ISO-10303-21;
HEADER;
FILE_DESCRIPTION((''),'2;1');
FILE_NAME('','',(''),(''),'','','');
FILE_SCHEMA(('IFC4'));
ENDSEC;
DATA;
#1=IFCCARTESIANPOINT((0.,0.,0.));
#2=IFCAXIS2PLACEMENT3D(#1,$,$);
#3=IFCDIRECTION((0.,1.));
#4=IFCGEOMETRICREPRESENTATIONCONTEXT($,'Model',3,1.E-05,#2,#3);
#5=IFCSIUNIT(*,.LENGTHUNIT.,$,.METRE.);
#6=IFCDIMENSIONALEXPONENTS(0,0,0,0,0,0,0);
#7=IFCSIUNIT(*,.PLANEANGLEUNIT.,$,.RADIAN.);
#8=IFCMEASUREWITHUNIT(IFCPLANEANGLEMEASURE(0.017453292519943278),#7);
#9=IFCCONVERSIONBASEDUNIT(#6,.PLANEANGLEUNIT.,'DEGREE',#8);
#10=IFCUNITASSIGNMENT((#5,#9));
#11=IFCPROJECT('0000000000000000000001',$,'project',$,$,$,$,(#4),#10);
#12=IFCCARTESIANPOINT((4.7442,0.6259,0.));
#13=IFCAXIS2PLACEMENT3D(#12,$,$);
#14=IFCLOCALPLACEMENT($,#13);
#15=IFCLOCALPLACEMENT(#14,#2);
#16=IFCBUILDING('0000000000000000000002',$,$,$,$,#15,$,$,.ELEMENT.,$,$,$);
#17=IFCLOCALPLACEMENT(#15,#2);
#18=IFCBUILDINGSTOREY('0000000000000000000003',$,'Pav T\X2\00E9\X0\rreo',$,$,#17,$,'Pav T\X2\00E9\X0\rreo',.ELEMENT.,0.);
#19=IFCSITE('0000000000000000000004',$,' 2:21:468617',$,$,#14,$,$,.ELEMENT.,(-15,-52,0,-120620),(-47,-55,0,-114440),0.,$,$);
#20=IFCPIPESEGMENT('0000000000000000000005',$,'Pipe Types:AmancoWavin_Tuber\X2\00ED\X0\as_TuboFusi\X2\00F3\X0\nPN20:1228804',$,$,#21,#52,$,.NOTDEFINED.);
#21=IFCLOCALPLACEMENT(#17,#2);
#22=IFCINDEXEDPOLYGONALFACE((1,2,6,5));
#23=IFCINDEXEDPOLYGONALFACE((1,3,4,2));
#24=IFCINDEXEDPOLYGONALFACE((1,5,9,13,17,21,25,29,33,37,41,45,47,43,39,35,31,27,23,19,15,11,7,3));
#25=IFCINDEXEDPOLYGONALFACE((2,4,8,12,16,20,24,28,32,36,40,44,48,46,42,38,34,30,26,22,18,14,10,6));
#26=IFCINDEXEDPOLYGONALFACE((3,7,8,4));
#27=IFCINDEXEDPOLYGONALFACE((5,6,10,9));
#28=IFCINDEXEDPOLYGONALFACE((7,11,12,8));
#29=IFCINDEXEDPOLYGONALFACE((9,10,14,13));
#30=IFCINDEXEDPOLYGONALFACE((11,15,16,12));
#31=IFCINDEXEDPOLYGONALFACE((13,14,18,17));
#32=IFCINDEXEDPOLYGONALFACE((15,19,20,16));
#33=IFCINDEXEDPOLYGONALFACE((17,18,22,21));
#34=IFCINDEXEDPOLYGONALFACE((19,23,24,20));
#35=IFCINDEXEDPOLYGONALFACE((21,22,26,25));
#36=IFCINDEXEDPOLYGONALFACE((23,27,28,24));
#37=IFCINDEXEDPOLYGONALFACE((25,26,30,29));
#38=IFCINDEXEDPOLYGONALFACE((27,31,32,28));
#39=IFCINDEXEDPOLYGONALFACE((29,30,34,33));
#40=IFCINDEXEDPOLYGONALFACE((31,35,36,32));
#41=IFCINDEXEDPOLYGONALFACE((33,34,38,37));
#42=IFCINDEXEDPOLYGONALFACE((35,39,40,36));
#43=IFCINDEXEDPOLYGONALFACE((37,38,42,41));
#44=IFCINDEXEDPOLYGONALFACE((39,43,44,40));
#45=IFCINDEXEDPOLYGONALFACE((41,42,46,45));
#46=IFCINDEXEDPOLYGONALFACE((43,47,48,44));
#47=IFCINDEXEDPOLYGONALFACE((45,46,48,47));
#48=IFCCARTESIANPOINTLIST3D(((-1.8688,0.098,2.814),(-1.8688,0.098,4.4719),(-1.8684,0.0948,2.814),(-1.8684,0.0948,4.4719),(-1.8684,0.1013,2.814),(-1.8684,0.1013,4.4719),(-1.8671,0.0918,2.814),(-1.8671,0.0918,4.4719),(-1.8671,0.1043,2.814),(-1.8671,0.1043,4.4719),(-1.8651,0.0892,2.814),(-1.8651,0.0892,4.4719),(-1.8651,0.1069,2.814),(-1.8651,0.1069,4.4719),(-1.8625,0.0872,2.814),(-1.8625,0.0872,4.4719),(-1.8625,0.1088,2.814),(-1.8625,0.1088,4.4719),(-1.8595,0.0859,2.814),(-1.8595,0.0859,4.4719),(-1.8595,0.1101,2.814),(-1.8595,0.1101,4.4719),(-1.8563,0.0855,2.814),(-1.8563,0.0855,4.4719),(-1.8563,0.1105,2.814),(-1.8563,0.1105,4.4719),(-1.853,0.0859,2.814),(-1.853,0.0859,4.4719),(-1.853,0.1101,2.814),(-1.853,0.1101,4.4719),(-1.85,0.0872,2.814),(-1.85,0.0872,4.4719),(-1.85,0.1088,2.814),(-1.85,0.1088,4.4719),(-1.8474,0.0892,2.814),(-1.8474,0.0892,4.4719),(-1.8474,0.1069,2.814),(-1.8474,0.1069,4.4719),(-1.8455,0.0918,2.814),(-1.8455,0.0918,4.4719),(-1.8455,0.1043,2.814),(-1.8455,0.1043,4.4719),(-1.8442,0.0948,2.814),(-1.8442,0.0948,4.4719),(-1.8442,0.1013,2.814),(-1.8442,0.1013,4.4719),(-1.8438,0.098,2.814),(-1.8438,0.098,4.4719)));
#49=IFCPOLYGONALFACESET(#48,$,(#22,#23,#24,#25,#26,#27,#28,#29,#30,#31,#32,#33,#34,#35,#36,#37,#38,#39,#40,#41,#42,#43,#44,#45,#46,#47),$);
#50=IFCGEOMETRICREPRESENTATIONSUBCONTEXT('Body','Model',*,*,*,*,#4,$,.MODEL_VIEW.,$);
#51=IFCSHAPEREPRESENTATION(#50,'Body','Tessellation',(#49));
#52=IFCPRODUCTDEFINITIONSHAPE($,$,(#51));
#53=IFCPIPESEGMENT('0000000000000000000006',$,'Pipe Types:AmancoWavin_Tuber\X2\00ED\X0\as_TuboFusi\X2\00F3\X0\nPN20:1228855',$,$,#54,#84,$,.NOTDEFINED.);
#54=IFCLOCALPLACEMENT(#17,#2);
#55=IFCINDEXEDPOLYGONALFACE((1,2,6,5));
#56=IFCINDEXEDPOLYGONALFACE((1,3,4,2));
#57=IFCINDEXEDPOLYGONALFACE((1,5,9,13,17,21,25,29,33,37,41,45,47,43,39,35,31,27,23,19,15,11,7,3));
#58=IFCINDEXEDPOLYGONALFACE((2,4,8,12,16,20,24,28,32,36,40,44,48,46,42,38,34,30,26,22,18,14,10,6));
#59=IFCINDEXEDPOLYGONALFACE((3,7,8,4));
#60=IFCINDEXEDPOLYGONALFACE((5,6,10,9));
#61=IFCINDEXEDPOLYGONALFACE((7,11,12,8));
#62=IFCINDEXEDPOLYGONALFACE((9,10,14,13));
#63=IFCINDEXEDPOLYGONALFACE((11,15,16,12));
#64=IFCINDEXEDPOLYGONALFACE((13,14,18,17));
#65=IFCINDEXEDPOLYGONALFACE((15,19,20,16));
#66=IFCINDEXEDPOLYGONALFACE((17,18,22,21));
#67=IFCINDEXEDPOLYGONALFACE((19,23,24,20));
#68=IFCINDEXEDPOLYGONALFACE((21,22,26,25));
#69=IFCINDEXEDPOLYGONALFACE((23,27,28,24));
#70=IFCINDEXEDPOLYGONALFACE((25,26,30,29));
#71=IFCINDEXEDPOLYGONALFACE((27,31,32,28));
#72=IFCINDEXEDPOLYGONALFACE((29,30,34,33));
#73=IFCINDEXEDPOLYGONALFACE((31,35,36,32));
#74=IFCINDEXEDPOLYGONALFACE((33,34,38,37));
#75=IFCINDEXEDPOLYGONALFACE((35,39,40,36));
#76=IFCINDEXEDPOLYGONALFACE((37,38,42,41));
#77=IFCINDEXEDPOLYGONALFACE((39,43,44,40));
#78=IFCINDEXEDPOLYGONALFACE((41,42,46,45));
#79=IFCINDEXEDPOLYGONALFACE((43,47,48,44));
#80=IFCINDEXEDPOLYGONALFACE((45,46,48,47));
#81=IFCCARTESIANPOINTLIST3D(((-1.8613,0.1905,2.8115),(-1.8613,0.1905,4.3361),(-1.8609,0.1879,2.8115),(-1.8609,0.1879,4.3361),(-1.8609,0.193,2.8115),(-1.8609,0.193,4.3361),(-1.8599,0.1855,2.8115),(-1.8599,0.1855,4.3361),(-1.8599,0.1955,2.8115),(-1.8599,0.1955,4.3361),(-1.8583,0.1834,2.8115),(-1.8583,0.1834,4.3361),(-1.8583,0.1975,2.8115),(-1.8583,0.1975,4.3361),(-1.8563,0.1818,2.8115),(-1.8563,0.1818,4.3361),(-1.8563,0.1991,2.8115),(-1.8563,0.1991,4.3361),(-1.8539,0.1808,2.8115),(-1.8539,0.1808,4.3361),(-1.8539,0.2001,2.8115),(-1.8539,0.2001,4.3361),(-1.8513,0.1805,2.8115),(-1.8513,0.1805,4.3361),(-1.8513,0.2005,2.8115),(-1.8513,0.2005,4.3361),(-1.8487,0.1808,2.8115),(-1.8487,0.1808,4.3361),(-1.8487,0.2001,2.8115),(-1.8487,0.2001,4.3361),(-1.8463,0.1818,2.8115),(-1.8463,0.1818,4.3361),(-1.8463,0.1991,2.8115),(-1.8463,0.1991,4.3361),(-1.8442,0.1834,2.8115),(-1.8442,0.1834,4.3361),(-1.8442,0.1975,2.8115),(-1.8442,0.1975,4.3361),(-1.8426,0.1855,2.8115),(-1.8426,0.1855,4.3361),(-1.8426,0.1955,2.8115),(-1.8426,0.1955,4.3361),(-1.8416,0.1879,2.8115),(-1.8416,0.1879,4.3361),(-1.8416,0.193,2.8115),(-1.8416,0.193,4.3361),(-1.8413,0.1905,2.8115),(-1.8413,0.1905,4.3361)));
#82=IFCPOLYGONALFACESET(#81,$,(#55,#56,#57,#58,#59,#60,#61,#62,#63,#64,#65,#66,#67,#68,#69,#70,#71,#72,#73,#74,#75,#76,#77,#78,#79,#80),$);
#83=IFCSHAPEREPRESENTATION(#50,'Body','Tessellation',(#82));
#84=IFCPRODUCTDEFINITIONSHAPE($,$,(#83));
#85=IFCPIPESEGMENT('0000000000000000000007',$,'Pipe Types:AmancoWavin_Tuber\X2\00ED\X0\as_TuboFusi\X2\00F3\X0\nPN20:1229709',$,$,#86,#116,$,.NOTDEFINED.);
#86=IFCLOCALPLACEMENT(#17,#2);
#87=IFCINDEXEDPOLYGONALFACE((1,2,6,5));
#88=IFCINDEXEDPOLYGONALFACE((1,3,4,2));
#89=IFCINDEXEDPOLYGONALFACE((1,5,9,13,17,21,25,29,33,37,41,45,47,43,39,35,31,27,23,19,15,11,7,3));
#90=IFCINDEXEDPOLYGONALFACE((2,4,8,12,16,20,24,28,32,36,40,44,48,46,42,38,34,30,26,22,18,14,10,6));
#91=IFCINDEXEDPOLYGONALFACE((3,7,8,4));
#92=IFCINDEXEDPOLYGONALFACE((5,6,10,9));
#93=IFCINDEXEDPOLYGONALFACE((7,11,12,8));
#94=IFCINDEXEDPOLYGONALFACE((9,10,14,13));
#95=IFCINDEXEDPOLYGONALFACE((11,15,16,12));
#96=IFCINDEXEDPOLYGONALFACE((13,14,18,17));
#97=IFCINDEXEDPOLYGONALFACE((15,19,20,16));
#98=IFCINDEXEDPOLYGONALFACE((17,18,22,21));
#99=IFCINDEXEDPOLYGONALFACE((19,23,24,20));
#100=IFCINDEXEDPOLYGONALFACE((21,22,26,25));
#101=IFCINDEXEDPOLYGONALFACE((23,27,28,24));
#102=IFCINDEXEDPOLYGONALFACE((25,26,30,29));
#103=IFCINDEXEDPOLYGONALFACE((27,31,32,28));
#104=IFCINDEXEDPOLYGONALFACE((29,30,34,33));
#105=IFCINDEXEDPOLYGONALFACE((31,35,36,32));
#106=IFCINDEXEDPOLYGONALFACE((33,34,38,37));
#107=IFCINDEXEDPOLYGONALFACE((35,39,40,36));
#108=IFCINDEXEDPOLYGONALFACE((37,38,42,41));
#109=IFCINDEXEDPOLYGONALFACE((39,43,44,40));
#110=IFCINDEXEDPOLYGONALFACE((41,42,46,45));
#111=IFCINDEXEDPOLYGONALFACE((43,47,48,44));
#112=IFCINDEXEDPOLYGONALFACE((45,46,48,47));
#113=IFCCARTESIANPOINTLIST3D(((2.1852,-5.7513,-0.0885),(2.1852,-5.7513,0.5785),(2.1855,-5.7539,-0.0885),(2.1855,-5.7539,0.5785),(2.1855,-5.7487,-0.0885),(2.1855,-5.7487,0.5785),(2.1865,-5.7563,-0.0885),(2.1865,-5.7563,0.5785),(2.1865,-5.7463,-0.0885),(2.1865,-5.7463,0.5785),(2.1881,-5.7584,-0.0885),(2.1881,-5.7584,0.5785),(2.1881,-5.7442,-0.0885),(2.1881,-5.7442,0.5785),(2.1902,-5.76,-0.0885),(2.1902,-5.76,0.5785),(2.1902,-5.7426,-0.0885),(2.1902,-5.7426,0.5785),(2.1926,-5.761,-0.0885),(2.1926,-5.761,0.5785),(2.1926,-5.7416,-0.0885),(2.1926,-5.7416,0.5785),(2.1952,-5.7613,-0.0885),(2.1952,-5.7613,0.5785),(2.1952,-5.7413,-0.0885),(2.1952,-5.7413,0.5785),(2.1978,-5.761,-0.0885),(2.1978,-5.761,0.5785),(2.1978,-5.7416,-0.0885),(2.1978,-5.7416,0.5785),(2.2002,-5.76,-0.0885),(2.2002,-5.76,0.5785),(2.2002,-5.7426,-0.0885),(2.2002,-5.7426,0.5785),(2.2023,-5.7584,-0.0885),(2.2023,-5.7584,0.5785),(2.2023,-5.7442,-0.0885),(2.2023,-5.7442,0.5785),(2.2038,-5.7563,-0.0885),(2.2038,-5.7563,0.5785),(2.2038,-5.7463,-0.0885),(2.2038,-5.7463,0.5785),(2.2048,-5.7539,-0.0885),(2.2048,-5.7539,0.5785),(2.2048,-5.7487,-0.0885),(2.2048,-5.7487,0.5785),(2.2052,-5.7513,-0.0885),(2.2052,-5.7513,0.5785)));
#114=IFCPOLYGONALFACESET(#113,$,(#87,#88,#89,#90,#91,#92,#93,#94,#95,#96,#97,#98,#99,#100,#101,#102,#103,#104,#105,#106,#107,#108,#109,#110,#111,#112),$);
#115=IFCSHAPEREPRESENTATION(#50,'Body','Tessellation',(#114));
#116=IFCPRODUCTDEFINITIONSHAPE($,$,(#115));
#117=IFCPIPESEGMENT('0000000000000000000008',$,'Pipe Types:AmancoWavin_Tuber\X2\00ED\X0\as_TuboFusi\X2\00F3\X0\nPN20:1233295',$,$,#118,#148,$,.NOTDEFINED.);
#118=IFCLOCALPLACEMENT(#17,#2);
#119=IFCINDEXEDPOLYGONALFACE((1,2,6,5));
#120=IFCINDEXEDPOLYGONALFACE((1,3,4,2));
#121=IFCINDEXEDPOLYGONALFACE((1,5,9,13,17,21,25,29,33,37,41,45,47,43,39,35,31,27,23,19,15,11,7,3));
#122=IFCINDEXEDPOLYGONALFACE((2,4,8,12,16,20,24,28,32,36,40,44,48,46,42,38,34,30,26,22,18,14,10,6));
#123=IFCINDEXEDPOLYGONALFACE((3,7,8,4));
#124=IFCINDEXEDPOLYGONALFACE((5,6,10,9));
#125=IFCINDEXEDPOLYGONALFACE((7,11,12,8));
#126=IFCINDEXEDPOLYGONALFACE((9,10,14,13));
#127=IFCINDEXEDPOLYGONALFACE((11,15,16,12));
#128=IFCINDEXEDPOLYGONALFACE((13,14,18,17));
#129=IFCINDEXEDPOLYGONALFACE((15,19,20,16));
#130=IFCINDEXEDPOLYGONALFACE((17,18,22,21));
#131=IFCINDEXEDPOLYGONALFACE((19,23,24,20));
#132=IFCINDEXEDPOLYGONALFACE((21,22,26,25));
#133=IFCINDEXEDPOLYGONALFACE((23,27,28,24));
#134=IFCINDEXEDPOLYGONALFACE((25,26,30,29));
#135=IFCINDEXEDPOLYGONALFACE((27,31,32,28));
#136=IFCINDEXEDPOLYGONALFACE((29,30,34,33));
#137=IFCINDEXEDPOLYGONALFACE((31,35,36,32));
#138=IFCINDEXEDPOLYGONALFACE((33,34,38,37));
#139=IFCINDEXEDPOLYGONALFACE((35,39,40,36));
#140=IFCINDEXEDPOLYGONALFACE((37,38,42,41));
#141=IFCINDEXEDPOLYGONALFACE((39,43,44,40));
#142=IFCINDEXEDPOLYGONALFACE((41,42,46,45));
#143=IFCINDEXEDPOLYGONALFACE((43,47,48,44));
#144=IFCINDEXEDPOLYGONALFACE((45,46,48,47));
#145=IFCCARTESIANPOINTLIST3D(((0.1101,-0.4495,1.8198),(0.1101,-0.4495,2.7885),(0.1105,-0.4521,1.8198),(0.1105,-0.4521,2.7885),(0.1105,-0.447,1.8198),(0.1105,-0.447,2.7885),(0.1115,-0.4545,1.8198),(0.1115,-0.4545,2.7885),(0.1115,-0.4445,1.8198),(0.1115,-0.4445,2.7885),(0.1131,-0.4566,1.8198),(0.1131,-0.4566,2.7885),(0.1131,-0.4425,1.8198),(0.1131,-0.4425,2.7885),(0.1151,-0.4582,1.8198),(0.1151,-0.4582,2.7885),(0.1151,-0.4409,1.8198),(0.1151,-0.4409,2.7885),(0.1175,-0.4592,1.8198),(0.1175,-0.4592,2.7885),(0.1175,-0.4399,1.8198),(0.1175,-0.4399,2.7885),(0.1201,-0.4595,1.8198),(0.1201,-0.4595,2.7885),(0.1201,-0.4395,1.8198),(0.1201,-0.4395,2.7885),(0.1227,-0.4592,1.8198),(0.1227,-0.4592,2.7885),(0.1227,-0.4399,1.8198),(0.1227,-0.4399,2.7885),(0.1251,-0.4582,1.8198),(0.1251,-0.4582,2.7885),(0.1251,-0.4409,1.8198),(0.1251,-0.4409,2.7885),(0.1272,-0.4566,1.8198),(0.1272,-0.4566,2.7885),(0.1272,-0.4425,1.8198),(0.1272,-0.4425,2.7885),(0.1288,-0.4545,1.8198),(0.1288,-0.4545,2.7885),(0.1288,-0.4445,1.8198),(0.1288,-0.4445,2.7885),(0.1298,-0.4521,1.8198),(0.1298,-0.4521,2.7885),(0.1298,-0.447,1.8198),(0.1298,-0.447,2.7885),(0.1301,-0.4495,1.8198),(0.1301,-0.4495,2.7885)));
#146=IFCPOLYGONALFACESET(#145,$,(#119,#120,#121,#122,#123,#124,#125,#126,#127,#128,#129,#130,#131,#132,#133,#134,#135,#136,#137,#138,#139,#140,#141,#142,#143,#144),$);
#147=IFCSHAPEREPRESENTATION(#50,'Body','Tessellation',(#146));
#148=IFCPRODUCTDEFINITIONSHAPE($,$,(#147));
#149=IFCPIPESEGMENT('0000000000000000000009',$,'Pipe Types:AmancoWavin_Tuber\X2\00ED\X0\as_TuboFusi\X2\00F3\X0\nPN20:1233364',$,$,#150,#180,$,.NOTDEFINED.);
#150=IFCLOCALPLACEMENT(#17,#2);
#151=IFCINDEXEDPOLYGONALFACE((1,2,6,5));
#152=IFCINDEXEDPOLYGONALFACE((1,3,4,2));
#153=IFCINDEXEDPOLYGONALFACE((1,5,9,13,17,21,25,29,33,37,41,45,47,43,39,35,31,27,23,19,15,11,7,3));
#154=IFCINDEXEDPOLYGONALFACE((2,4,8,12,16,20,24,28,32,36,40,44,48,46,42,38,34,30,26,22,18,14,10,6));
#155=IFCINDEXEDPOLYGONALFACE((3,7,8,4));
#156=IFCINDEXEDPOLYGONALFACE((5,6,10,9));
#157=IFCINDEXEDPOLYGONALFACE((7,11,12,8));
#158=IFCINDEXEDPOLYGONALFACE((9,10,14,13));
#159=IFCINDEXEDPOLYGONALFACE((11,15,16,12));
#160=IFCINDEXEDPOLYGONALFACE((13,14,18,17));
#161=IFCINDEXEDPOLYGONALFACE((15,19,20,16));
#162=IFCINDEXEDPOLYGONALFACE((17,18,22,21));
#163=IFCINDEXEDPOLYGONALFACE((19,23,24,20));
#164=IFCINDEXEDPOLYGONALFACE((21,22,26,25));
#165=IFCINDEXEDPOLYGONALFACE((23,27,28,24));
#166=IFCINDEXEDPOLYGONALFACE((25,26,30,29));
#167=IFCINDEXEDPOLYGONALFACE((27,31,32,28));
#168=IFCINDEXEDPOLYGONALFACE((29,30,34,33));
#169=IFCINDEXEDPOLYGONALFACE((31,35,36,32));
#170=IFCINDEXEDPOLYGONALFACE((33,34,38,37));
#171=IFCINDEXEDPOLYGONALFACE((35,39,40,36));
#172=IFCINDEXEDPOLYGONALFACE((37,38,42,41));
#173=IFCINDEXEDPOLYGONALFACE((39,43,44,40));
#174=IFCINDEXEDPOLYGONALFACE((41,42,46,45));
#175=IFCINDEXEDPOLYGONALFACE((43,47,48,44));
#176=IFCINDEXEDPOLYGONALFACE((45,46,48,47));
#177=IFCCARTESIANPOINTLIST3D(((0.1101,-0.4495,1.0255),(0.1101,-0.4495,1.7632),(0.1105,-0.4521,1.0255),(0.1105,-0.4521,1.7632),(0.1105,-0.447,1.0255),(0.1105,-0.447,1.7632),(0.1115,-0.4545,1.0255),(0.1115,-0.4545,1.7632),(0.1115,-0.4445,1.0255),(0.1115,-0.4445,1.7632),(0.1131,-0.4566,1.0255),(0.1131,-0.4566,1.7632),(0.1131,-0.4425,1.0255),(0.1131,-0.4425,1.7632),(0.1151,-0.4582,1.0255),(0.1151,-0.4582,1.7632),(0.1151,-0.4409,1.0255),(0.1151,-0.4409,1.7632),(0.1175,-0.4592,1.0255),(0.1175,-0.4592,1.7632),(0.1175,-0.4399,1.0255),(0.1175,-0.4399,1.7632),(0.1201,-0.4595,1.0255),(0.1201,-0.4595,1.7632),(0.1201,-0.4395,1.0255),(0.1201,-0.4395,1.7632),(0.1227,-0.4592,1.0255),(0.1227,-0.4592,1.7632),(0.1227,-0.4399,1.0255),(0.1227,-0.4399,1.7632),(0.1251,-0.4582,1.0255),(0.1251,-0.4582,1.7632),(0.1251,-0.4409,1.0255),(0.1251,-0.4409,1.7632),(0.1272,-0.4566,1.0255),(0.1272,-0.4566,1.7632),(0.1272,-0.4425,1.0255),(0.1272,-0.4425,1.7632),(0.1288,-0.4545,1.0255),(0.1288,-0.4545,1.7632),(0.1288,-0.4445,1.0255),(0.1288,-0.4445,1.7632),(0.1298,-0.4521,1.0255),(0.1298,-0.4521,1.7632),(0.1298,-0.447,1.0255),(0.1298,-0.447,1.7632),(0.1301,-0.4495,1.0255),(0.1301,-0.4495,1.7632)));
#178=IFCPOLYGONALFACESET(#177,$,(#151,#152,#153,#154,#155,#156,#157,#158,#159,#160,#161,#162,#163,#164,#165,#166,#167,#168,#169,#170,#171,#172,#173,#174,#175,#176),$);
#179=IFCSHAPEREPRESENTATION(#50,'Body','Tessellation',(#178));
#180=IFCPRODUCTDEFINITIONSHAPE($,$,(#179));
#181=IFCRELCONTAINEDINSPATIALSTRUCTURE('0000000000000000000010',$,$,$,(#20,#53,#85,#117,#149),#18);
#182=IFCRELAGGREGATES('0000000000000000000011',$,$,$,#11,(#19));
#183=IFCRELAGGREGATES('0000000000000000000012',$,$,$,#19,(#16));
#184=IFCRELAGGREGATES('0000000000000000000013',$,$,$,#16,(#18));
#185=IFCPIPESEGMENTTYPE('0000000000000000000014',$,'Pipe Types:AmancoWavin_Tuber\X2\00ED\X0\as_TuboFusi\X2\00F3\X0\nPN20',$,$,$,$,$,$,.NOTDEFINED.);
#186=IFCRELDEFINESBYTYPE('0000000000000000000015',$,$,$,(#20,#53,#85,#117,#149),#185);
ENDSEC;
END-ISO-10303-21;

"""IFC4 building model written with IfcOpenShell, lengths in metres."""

from ifc_helpers import new_model, entity, si_unit, converted_unit, direction, frame, origin, place, context, subcontext, project, spatial, arc, indexed_curve, outline, extrude, type_object, element, save


model = new_model("IFC4")

# Units and contexts
model_context = context("Model", 3, precision=1e-05, world=origin(), true_north=direction((0.0, 1.0)))
body_context = subcontext(model_context, "Body", "Model", "MODEL_VIEW")
ifc_project = project(units=[si_unit("LENGTHUNIT", "METRE"), converted_unit("PLANEANGLEUNIT", "DEGREE", entity("IfcPlaneAngleMeasure", 0.017453292519943278), si_unit("PLANEANGLEUNIT", "RADIAN"), dimensions=[0, 0, 0, 0, 0, 0, 0])], contexts=[model_context])

# Site, building, storey
site_placement = place(None, frame((4.7442, 0.6259, 0.0)))
site = spatial("IfcSite", under=ifc_project, at=site_placement, Name=" 2:21:468617", CompositionType="ELEMENT", RefLatitude=(-15, -52, 0, -120620), RefLongitude=(-47, -55, 0, -114440), RefElevation=0.0)
building_placement = place(site_placement, origin())
building = spatial("IfcBuilding", under=site, at=building_placement, CompositionType="ELEMENT")
storey_placement = place(building_placement, origin())
storey = spatial("IfcBuildingStorey", under=building, at=storey_placement, Name="Pav Térreo", LongName="Pav Térreo", CompositionType="ELEMENT", Elevation=0.0)

# Pipe segments
pipe_segment_type_1 = type_object("IfcPipeSegmentType", Name="Pipe Types:AmancoWavin_Tuberías_TuboFusiónPN20", PredefinedType="NOTDEFINED")
pipe_segment_1_placement = place(storey_placement, origin())
element("IfcPipeSegment", 1, at=pipe_segment_1_placement, inside=storey, type_object=pipe_segment_type_1, Name="Pipe Types:AmancoWavin_Tuberías_TuboFusiónPN20:1228804", PredefinedType="NOTDEFINED", context=body_context, shape_type="SweptSolid", body=[
    extrude(outline(indexed_curve([(0.0125, 0.0), (0.0088, 0.0088), (0.0, 0.0125), (-0.0088, 0.0088), (-0.0125, 0.0), (-0.0088, -0.0088), (0.0, -0.0125), (0.0088, -0.0088)], segments=[arc(1, 2, 3), arc(3, 4, 5), arc(5, 6, 7), arc(7, 8, 1)], self_intersect=False)), frame((-1.8563, 0.098, 2.814)), (0.0, 0.0, 1.0), 1.6579),
])
pipe_segment_2_placement = place(storey_placement, origin())
element("IfcPipeSegment", 2, at=pipe_segment_2_placement, inside=storey, type_object=pipe_segment_type_1, Name="Pipe Types:AmancoWavin_Tuberías_TuboFusiónPN20:1228855", PredefinedType="NOTDEFINED", context=body_context, shape_type="SweptSolid", body=[
    extrude(outline(indexed_curve([(0.01, 0.0), (0.0071, 0.0071), (0.0, 0.01), (-0.0071, 0.0071), (-0.01, 0.0), (-0.0071, -0.0071), (0.0, -0.01), (0.0071, -0.0071)], segments=[arc(1, 2, 3), arc(3, 4, 5), arc(5, 6, 7), arc(7, 8, 1)], self_intersect=False)), frame((-1.8513, 0.1905, 2.8115), z_axis=(0.0, 0.0, 1.0), x_axis=(-1.0, 0.0, 0.0)), (0.0, 0.0, 1.0), 1.5246),
])
pipe_segment_3_placement = place(storey_placement, origin())
element("IfcPipeSegment", 3, at=pipe_segment_3_placement, inside=storey, type_object=pipe_segment_type_1, Name="Pipe Types:AmancoWavin_Tuberías_TuboFusiónPN20:1229709", PredefinedType="NOTDEFINED", context=body_context, shape_type="SweptSolid", body=[
    extrude(outline(indexed_curve([(0.01, 0.0), (0.0071, 0.0071), (0.0, 0.01), (-0.0071, 0.0071), (-0.01, 0.0), (-0.0071, -0.0071), (0.0, -0.01), (0.0071, -0.0071)], segments=[arc(1, 2, 3), arc(3, 4, 5), arc(5, 6, 7), arc(7, 8, 1)], self_intersect=False)), frame((2.1952, -5.7513, -0.0885), z_axis=(0.0, 0.0, 1.0), x_axis=(-1.0, 0.0, 0.0)), (0.0, 0.0, 1.0), 0.667),
])
pipe_segment_4_placement = place(storey_placement, origin())
element("IfcPipeSegment", 4, at=pipe_segment_4_placement, inside=storey, type_object=pipe_segment_type_1, Name="Pipe Types:AmancoWavin_Tuberías_TuboFusiónPN20:1233295", PredefinedType="NOTDEFINED", context=body_context, shape_type="SweptSolid", body=[
    extrude(outline(indexed_curve([(0.01, 0.0), (0.0071, 0.0071), (0.0, 0.01), (-0.0071, 0.0071), (-0.01, 0.0), (-0.0071, -0.0071), (0.0, -0.01), (0.0071, -0.0071)], segments=[arc(1, 2, 3), arc(3, 4, 5), arc(5, 6, 7), arc(7, 8, 1)], self_intersect=False)), frame((0.1201, -0.4495, 1.8198)), (0.0, 0.0, 1.0), 0.9687),
])
pipe_segment_5_placement = place(storey_placement, origin())
element("IfcPipeSegment", 5, at=pipe_segment_5_placement, inside=storey, type_object=pipe_segment_type_1, Name="Pipe Types:AmancoWavin_Tuberías_TuboFusiónPN20:1233364", PredefinedType="NOTDEFINED", context=body_context, shape_type="SweptSolid", body=[
    extrude(outline(indexed_curve([(0.01, 0.0), (0.0071, 0.0071), (0.0, 0.01), (-0.0071, 0.0071), (-0.01, 0.0), (-0.0071, -0.0071), (0.0, -0.01), (0.0071, -0.0071)], segments=[arc(1, 2, 3), arc(3, 4, 5), arc(5, 6, 7), arc(7, 8, 1)], self_intersect=False)), frame((0.1201, -0.4495, 1.0255)), (0.0, 0.0, 1.0), 0.7377),
])

save(model, "model.ifc")
